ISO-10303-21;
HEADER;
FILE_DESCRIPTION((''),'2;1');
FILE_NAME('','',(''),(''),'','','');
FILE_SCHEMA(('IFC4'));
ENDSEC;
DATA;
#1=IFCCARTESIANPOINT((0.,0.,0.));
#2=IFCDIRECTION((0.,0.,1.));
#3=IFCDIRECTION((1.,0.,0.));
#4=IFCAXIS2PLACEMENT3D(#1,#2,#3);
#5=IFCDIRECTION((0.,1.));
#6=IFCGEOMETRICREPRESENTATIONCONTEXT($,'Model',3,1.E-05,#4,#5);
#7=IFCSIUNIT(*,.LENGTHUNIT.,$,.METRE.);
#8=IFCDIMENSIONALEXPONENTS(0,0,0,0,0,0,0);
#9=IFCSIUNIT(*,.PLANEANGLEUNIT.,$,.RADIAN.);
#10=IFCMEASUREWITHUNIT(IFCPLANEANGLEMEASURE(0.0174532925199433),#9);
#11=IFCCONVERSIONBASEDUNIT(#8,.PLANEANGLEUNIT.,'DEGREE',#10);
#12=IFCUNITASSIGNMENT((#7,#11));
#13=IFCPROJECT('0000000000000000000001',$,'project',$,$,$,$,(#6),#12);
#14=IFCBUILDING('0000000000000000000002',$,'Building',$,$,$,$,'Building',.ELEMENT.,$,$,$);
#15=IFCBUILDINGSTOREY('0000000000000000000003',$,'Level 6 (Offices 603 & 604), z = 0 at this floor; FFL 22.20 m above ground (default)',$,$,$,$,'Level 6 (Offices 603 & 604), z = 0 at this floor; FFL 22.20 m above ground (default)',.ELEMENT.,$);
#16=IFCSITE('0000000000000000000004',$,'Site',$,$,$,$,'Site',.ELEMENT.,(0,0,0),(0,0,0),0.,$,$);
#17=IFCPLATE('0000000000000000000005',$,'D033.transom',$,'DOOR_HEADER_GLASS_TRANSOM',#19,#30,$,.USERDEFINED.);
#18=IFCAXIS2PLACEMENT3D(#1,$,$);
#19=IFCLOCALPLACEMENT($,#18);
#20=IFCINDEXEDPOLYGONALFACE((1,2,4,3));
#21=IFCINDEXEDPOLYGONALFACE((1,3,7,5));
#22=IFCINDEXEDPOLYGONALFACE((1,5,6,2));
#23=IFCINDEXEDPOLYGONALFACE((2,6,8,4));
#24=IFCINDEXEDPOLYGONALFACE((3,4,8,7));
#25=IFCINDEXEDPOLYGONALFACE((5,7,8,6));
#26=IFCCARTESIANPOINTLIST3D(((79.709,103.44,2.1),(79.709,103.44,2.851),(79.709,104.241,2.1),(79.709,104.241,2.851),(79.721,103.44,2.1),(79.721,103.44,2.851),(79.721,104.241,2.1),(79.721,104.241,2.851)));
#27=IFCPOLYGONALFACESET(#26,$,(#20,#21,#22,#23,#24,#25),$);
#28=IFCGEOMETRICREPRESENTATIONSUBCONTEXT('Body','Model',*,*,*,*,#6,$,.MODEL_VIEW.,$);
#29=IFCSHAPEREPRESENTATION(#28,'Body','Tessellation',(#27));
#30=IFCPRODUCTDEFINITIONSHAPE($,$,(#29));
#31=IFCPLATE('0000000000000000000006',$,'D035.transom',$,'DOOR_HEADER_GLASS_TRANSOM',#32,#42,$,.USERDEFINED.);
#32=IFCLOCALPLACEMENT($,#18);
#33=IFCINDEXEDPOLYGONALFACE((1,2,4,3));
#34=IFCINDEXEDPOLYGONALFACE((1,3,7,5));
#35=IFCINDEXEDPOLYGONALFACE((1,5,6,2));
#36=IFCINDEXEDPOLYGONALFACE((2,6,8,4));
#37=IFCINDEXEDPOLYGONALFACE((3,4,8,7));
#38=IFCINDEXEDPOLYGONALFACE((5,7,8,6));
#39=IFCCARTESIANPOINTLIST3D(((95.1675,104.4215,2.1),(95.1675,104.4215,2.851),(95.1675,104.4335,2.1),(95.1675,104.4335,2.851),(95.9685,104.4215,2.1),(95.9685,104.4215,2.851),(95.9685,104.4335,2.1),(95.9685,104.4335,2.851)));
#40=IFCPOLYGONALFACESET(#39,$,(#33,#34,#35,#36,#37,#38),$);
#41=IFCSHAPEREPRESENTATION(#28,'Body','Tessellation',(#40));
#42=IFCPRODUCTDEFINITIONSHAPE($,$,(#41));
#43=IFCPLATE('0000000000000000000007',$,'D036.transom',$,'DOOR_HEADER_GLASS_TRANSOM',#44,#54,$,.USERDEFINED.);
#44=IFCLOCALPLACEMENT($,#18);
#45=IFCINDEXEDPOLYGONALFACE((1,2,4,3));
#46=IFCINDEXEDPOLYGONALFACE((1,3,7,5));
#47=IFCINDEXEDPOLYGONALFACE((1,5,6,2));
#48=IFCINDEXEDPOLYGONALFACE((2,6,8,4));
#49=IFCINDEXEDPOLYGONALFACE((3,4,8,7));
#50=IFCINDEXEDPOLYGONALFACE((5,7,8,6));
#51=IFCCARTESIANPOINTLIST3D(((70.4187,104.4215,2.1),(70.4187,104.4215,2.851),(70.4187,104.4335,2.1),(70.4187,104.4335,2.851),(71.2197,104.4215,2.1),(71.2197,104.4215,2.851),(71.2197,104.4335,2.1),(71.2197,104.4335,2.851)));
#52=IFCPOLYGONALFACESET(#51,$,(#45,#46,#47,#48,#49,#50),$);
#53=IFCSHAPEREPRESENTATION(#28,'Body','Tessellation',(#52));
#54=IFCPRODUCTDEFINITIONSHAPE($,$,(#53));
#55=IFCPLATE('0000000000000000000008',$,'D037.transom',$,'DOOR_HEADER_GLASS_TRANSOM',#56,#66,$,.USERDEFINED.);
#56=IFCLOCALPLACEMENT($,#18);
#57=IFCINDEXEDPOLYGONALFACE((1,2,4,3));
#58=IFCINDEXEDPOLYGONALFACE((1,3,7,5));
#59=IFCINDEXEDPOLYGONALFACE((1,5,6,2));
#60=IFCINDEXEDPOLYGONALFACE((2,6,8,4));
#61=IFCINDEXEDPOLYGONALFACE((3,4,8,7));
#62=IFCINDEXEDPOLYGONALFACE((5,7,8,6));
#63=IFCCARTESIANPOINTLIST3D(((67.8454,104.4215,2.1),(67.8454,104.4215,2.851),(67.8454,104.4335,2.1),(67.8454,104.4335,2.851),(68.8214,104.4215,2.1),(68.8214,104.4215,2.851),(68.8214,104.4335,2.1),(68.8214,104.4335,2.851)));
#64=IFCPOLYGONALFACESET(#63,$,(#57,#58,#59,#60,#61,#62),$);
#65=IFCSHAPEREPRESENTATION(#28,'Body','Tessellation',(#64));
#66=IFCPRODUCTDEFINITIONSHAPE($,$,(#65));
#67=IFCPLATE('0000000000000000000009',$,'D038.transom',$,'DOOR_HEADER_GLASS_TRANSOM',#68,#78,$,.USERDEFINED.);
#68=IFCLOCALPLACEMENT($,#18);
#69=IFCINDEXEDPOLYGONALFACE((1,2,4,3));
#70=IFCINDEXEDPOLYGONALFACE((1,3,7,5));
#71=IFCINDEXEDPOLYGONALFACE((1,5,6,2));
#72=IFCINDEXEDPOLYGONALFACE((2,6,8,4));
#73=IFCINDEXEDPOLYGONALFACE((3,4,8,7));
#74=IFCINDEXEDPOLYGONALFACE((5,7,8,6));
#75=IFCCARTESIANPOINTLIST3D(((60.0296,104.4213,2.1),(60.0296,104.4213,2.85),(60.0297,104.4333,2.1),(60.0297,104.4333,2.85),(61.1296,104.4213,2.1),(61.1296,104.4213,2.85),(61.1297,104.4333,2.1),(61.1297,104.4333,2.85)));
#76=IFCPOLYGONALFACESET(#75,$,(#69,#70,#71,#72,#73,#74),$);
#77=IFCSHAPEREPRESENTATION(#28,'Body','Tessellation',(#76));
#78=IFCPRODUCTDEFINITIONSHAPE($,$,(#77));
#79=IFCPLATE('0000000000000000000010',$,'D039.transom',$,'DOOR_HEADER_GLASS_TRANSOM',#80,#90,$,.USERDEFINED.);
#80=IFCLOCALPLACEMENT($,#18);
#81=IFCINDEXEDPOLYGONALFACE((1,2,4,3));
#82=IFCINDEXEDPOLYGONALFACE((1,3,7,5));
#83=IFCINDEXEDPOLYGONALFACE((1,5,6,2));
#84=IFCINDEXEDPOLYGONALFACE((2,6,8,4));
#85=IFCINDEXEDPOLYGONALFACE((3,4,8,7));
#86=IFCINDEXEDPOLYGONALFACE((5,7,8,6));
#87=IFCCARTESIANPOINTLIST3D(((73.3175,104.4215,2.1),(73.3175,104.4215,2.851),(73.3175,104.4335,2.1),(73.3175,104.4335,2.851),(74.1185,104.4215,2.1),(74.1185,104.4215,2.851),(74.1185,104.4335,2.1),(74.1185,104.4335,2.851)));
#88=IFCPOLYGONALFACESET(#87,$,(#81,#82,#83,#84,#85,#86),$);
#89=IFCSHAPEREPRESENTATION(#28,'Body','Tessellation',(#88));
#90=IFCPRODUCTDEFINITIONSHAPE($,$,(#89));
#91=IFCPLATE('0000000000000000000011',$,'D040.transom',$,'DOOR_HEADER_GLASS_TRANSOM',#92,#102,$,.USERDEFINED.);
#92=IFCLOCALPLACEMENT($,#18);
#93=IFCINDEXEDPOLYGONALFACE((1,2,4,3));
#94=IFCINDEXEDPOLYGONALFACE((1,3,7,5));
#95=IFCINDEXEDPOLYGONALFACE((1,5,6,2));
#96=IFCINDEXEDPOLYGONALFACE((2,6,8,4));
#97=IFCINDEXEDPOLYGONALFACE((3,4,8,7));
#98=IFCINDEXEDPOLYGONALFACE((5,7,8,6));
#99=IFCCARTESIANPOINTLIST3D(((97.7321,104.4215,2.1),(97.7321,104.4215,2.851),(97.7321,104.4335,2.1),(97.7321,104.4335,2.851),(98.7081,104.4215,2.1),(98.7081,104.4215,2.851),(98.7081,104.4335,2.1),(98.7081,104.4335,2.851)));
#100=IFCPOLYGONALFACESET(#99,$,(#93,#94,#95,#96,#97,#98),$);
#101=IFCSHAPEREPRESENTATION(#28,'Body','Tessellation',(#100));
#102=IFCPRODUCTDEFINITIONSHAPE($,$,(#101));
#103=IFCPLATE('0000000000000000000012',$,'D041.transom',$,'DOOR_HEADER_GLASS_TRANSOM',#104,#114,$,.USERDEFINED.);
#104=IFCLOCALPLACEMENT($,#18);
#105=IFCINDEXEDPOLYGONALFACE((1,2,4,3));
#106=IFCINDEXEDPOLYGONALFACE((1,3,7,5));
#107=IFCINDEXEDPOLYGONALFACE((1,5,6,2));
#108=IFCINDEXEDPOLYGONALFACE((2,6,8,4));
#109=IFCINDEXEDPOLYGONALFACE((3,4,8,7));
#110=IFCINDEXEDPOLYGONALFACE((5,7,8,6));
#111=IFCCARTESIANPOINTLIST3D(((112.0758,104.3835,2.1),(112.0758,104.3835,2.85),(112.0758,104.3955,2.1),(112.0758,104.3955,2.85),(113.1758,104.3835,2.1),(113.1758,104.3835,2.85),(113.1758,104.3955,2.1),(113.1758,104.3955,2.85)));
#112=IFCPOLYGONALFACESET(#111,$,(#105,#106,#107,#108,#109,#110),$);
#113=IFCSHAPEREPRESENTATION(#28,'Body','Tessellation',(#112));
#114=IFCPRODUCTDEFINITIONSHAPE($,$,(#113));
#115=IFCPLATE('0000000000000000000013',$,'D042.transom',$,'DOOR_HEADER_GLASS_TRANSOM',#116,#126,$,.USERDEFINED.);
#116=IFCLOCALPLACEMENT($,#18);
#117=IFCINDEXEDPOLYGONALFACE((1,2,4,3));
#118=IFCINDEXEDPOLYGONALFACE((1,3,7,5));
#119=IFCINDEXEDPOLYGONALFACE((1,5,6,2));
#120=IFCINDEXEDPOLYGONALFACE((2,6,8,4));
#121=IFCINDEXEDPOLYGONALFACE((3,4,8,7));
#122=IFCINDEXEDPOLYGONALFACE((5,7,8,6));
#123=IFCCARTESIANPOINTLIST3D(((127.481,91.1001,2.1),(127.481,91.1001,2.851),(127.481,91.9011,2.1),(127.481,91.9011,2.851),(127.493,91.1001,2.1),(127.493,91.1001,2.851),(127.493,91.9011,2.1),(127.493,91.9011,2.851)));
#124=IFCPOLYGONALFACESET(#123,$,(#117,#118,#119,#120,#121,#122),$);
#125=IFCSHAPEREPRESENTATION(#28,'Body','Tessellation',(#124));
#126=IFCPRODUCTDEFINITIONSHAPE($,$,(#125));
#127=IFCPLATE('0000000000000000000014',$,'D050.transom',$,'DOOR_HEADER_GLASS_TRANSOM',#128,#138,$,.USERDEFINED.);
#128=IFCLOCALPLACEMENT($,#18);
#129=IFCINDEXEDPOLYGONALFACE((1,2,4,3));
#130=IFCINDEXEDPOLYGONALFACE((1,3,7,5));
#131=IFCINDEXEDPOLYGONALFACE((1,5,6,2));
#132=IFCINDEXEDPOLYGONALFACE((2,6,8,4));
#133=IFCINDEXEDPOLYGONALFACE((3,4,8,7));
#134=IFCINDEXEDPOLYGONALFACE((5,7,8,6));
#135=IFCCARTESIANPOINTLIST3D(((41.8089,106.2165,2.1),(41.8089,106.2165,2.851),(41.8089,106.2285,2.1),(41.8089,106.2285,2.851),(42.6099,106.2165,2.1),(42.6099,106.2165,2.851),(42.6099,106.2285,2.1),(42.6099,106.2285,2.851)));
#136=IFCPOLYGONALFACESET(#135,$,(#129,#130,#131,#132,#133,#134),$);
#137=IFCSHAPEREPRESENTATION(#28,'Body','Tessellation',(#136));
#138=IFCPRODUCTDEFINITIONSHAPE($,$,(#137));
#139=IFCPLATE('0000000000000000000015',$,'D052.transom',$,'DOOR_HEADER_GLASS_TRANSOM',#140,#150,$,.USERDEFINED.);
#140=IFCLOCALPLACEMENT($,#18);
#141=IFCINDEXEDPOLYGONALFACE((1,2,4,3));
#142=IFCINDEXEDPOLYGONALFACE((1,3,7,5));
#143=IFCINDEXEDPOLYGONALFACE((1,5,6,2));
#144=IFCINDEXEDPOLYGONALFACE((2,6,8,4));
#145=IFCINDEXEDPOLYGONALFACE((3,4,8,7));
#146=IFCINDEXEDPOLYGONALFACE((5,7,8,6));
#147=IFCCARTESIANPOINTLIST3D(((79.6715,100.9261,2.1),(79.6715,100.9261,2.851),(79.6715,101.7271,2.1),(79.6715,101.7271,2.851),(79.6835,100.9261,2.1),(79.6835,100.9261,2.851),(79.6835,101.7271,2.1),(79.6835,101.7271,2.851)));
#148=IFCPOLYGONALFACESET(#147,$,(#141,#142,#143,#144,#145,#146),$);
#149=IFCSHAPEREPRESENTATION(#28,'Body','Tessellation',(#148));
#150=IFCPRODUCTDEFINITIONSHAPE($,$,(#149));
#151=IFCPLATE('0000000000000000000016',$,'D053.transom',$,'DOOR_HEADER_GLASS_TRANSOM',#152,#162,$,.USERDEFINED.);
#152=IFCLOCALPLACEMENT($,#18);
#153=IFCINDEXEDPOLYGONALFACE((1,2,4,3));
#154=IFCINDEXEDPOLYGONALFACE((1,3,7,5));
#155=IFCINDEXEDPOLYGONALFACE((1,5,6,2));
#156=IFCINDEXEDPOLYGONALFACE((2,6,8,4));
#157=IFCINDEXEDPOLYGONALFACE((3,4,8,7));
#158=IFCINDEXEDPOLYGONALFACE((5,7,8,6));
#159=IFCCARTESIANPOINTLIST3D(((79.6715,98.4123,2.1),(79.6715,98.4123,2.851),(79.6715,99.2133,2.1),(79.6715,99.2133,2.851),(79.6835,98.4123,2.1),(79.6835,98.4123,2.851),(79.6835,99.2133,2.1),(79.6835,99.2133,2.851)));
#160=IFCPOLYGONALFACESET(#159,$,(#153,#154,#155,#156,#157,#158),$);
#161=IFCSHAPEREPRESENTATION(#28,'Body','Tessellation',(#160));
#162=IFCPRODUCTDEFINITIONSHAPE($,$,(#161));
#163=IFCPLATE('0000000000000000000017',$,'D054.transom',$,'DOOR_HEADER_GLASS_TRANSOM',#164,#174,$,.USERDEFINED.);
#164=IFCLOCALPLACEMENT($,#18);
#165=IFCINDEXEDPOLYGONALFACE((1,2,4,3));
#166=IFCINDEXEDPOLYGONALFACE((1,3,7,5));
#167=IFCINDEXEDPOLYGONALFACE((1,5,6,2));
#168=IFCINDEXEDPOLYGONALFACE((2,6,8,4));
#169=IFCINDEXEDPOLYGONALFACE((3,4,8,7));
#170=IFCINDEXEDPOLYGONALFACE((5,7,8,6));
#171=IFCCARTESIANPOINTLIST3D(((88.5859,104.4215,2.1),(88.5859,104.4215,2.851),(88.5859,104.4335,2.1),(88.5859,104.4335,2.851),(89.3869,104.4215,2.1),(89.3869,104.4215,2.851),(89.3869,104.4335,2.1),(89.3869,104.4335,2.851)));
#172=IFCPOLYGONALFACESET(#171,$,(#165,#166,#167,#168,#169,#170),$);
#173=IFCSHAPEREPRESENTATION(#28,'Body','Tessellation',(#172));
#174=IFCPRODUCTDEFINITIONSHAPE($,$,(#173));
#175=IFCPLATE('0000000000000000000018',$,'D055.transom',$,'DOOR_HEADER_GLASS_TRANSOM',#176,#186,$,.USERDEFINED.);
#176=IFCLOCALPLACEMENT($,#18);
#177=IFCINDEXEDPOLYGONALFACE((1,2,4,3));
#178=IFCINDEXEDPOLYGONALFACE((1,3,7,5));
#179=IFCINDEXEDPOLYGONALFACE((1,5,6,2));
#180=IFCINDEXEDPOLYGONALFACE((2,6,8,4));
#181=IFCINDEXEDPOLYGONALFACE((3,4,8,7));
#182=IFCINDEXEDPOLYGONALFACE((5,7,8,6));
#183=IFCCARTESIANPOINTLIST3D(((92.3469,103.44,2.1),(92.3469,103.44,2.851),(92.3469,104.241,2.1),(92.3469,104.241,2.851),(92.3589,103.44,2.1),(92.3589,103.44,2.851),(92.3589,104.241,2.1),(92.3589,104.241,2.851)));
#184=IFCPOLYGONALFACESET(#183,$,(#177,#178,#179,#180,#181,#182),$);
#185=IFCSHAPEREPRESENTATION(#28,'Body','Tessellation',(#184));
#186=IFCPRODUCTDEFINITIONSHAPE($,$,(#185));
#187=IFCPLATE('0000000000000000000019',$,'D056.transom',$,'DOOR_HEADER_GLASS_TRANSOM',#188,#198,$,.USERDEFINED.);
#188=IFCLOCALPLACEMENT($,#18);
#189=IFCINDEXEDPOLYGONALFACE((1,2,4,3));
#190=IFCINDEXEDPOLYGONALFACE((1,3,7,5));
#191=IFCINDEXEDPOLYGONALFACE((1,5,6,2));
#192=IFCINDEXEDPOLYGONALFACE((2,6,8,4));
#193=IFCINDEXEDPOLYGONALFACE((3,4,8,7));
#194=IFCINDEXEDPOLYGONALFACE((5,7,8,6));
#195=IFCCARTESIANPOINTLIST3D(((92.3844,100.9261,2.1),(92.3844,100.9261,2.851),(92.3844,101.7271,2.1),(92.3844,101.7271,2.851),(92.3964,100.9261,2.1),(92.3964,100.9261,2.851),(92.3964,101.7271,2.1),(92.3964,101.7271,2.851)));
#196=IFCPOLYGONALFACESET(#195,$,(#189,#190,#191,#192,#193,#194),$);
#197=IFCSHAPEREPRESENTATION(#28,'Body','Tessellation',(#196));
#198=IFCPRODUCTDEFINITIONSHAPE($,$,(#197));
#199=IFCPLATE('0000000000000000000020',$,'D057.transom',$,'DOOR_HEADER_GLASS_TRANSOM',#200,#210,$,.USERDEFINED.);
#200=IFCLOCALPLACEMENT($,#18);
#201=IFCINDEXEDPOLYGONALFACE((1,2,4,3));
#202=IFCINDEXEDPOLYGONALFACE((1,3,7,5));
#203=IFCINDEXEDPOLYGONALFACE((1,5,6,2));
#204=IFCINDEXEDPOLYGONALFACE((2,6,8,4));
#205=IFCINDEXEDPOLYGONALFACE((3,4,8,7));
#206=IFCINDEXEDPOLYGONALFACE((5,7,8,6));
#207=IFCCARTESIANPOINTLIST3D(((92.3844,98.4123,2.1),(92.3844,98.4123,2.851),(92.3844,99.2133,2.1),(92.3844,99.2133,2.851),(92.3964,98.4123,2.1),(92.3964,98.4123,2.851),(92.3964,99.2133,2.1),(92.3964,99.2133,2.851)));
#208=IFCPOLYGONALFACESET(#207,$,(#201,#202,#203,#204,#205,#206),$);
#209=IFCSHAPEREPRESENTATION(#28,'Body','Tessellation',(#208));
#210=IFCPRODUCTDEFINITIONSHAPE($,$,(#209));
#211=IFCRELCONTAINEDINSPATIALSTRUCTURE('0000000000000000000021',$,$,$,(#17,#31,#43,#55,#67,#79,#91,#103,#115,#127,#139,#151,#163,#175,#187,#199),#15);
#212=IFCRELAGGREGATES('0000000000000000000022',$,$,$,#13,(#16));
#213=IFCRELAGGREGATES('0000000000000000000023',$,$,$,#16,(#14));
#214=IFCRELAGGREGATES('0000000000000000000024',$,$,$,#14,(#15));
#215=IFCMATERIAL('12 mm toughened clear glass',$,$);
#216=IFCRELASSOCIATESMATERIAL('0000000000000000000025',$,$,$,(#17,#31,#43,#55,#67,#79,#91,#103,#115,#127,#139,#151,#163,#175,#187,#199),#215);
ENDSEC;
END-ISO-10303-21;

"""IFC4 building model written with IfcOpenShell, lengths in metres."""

from ifc_helpers import new_model, entity, si_unit, converted_unit, direction, frame, frame_2d, origin_with_axes, origin_2d_with_axis, place, context, subcontext, project, spatial, rectangle, extrude, material, element, save


model = new_model("IFC4")

# Units and contexts
model_context = context("Model", 3, precision=1e-05, world=origin_with_axes(), true_north=direction((0.0, 1.0)))
body_context = subcontext(model_context, "Body", "Model", "MODEL_VIEW")
ifc_project = project(units=[si_unit("LENGTHUNIT", "METRE"), converted_unit("PLANEANGLEUNIT", "DEGREE", entity("IfcPlaneAngleMeasure", 0.0174532925199433), si_unit("PLANEANGLEUNIT", "RADIAN"), dimensions=[0, 0, 0, 0, 0, 0, 0])], contexts=[model_context])

# Site, building, storey
site = spatial("IfcSite", under=ifc_project, Name="Site", LongName="Site", CompositionType="ELEMENT", RefLatitude=(0, 0, 0), RefLongitude=(0, 0, 0), RefElevation=0.0)
building = spatial("IfcBuilding", under=site, Name="Building", LongName="Building", CompositionType="ELEMENT")
storey = spatial("IfcBuildingStorey", under=building, Name="Level 6 (Offices 603 & 604), z = 0 at this floor; FFL 22.20 m above ground (default)", LongName="Level 6 (Offices 603 & 604), z = 0 at this floor; FFL 22.20 m above ground (default)", CompositionType="ELEMENT")

# Plates
ifc_material_1 = material(Name="12 mm toughened clear glass")
placement = place(None, origin_with_axes())
element("IfcPlate", 1, at=placement, inside=storey, material=ifc_material_1, Name="D033.transom", ObjectType="DOOR_HEADER_GLASS_TRANSOM", PredefinedType="USERDEFINED", context=body_context, shape_type="SweptSolid", body=[
    extrude(rectangle(XDim=0.801, YDim=0.012, at=frame_2d((0.0, 0.0), x_axis=(0.0, 1.0))), frame((79.715, 103.8405, 2.1), z_axis=(0.0, 0.0, 1.0), x_axis=(1.0, 0.0, 0.0)), (0.0, 0.0, 1.0), 0.751),
])
element("IfcPlate", 2, at=placement, inside=storey, material=ifc_material_1, Name="D035.transom", ObjectType="DOOR_HEADER_GLASS_TRANSOM", PredefinedType="USERDEFINED", context=body_context, shape_type="SweptSolid", body=[
    extrude(rectangle(XDim=0.801, YDim=0.012, at=origin_2d_with_axis()), frame((95.568, 104.4275, 2.1), z_axis=(0.0, 0.0, 1.0), x_axis=(1.0, 0.0, 0.0)), (0.0, 0.0, 1.0), 0.751),
])
element("IfcPlate", 3, at=placement, inside=storey, material=ifc_material_1, Name="D036.transom", ObjectType="DOOR_HEADER_GLASS_TRANSOM", PredefinedType="USERDEFINED", context=body_context, shape_type="SweptSolid", body=[
    extrude(rectangle(XDim=0.801, YDim=0.012, at=origin_2d_with_axis()), frame((70.8192, 104.4275, 2.1), z_axis=(0.0, 0.0, 1.0), x_axis=(1.0, 0.0, 0.0)), (0.0, 0.0, 1.0), 0.751),
])
element("IfcPlate", 4, at=placement, inside=storey, material=ifc_material_1, Name="D037.transom", ObjectType="DOOR_HEADER_GLASS_TRANSOM", PredefinedType="USERDEFINED", context=body_context, shape_type="SweptSolid", body=[
    extrude(rectangle(XDim=0.976, YDim=0.012, at=frame_2d((0.0, 0.0), x_axis=(1.0, 0.0))), frame((68.3334, 104.4275, 2.1), z_axis=(0.0, 0.0, 1.0), x_axis=(1.0, 0.0, 0.0)), (0.0, 0.0, 1.0), 0.751),
])
element("IfcPlate", 5, at=placement, inside=storey, material=ifc_material_1, Name="D038.transom", ObjectType="DOOR_HEADER_GLASS_TRANSOM", PredefinedType="USERDEFINED", context=body_context, shape_type="SweptSolid", body=[
    extrude(rectangle(XDim=1.1, YDim=0.012, at=frame_2d((0.0, 0.0), x_axis=(1.0, -0.00002))), frame((60.5797, 104.4273, 2.1), z_axis=(0.0, 0.0, 1.0), x_axis=(1.0, 0.0, 0.0)), (0.0, 0.0, 1.0), 0.75),
])
element("IfcPlate", 6, at=placement, inside=storey, material=ifc_material_1, Name="D039.transom", ObjectType="DOOR_HEADER_GLASS_TRANSOM", PredefinedType="USERDEFINED", context=body_context, shape_type="SweptSolid", body=[
    extrude(rectangle(XDim=0.801, YDim=0.012, at=origin_2d_with_axis()), frame((73.718, 104.4275, 2.1), z_axis=(0.0, 0.0, 1.0), x_axis=(1.0, 0.0, 0.0)), (0.0, 0.0, 1.0), 0.751),
])
element("IfcPlate", 7, at=placement, inside=storey, material=ifc_material_1, Name="D040.transom", ObjectType="DOOR_HEADER_GLASS_TRANSOM", PredefinedType="USERDEFINED", context=body_context, shape_type="SweptSolid", body=[
    extrude(rectangle(XDim=0.976, YDim=0.012, at=frame_2d((0.0, 0.0), x_axis=(1.0, 0.0))), frame((98.2201, 104.4275, 2.1), z_axis=(0.0, 0.0, 1.0), x_axis=(1.0, 0.0, 0.0)), (0.0, 0.0, 1.0), 0.751),
])
element("IfcPlate", 8, at=placement, inside=storey, material=ifc_material_1, Name="D041.transom", ObjectType="DOOR_HEADER_GLASS_TRANSOM", PredefinedType="USERDEFINED", context=body_context, shape_type="SweptSolid", body=[
    extrude(rectangle(XDim=1.1, YDim=0.012, at=origin_2d_with_axis()), frame((112.6258, 104.3895, 2.1), z_axis=(0.0, 0.0, 1.0), x_axis=(1.0, 0.0, 0.0)), (0.0, 0.0, 1.0), 0.75),
])
element("IfcPlate", 9, at=placement, inside=storey, material=ifc_material_1, Name="D042.transom", ObjectType="DOOR_HEADER_GLASS_TRANSOM", PredefinedType="USERDEFINED", context=body_context, shape_type="SweptSolid", body=[
    extrude(rectangle(XDim=0.801, YDim=0.012, at=frame_2d((0.0, 0.0), x_axis=(-0.000008, 1.0))), frame((127.487, 91.5006, 2.1), z_axis=(0.0, 0.0, 1.0), x_axis=(1.0, 0.0, 0.0)), (0.0, 0.0, 1.0), 0.751),
])
element("IfcPlate", 10, at=placement, inside=storey, material=ifc_material_1, Name="D050.transom", ObjectType="DOOR_HEADER_GLASS_TRANSOM", PredefinedType="USERDEFINED", context=body_context, shape_type="SweptSolid", body=[
    extrude(rectangle(XDim=0.801, YDim=0.012, at=frame_2d((0.0, 0.0), x_axis=(1.0, 0.0))), frame((42.2094, 106.2225, 2.1), z_axis=(0.0, 0.0, 1.0), x_axis=(1.0, 0.0, 0.0)), (0.0, 0.0, 1.0), 0.751),
])
element("IfcPlate", 11, at=placement, inside=storey, material=ifc_material_1, Name="D052.transom", ObjectType="DOOR_HEADER_GLASS_TRANSOM", PredefinedType="USERDEFINED", context=body_context, shape_type="SweptSolid", body=[
    extrude(rectangle(XDim=0.801, YDim=0.012, at=frame_2d((0.0, 0.0), x_axis=(0.0, 1.0))), frame((79.6775, 101.3266, 2.1), z_axis=(0.0, 0.0, 1.0), x_axis=(1.0, 0.0, 0.0)), (0.0, 0.0, 1.0), 0.751),
])
element("IfcPlate", 12, at=placement, inside=storey, material=ifc_material_1, Name="D053.transom", ObjectType="DOOR_HEADER_GLASS_TRANSOM", PredefinedType="USERDEFINED", context=body_context, shape_type="SweptSolid", body=[
    extrude(rectangle(XDim=0.801, YDim=0.012, at=frame_2d((0.0, 0.0), x_axis=(0.0, 1.0))), frame((79.6775, 98.8128, 2.1), z_axis=(0.0, 0.0, 1.0), x_axis=(1.0, 0.0, 0.0)), (0.0, 0.0, 1.0), 0.751),
])
element("IfcPlate", 13, at=placement, inside=storey, material=ifc_material_1, Name="D054.transom", ObjectType="DOOR_HEADER_GLASS_TRANSOM", PredefinedType="USERDEFINED", context=body_context, shape_type="SweptSolid", body=[
    extrude(rectangle(XDim=0.801, YDim=0.012, at=origin_2d_with_axis()), frame((88.9864, 104.4275, 2.1), z_axis=(0.0, 0.0, 1.0), x_axis=(1.0, 0.0, 0.0)), (0.0, 0.0, 1.0), 0.751),
])
element("IfcPlate", 14, at=placement, inside=storey, material=ifc_material_1, Name="D055.transom", ObjectType="DOOR_HEADER_GLASS_TRANSOM", PredefinedType="USERDEFINED", context=body_context, shape_type="SweptSolid", body=[
    extrude(rectangle(XDim=0.801, YDim=0.012, at=frame_2d((0.0, 0.0), x_axis=(0.0, 1.0))), frame((92.3529, 103.8405, 2.1), z_axis=(0.0, 0.0, 1.0), x_axis=(1.0, 0.0, 0.0)), (0.0, 0.0, 1.0), 0.751),
])
element("IfcPlate", 15, at=placement, inside=storey, material=ifc_material_1, Name="D056.transom", ObjectType="DOOR_HEADER_GLASS_TRANSOM", PredefinedType="USERDEFINED", context=body_context, shape_type="SweptSolid", body=[
    extrude(rectangle(XDim=0.801, YDim=0.012, at=frame_2d((0.0, 0.0), x_axis=(0.0, 1.0))), frame((92.3904, 101.3266, 2.1), z_axis=(0.0, 0.0, 1.0), x_axis=(1.0, 0.0, 0.0)), (0.0, 0.0, 1.0), 0.751),
])
element("IfcPlate", 16, at=placement, inside=storey, material=ifc_material_1, Name="D057.transom", ObjectType="DOOR_HEADER_GLASS_TRANSOM", PredefinedType="USERDEFINED", context=body_context, shape_type="SweptSolid", body=[
    extrude(rectangle(XDim=0.801, YDim=0.012, at=frame_2d((0.0, 0.0), x_axis=(0.0, 1.0))), frame((92.3904, 98.8128, 2.1), z_axis=(0.0, 0.0, 1.0), x_axis=(1.0, 0.0, 0.0)), (0.0, 0.0, 1.0), 0.751),
])

save(model, "model.ifc")
